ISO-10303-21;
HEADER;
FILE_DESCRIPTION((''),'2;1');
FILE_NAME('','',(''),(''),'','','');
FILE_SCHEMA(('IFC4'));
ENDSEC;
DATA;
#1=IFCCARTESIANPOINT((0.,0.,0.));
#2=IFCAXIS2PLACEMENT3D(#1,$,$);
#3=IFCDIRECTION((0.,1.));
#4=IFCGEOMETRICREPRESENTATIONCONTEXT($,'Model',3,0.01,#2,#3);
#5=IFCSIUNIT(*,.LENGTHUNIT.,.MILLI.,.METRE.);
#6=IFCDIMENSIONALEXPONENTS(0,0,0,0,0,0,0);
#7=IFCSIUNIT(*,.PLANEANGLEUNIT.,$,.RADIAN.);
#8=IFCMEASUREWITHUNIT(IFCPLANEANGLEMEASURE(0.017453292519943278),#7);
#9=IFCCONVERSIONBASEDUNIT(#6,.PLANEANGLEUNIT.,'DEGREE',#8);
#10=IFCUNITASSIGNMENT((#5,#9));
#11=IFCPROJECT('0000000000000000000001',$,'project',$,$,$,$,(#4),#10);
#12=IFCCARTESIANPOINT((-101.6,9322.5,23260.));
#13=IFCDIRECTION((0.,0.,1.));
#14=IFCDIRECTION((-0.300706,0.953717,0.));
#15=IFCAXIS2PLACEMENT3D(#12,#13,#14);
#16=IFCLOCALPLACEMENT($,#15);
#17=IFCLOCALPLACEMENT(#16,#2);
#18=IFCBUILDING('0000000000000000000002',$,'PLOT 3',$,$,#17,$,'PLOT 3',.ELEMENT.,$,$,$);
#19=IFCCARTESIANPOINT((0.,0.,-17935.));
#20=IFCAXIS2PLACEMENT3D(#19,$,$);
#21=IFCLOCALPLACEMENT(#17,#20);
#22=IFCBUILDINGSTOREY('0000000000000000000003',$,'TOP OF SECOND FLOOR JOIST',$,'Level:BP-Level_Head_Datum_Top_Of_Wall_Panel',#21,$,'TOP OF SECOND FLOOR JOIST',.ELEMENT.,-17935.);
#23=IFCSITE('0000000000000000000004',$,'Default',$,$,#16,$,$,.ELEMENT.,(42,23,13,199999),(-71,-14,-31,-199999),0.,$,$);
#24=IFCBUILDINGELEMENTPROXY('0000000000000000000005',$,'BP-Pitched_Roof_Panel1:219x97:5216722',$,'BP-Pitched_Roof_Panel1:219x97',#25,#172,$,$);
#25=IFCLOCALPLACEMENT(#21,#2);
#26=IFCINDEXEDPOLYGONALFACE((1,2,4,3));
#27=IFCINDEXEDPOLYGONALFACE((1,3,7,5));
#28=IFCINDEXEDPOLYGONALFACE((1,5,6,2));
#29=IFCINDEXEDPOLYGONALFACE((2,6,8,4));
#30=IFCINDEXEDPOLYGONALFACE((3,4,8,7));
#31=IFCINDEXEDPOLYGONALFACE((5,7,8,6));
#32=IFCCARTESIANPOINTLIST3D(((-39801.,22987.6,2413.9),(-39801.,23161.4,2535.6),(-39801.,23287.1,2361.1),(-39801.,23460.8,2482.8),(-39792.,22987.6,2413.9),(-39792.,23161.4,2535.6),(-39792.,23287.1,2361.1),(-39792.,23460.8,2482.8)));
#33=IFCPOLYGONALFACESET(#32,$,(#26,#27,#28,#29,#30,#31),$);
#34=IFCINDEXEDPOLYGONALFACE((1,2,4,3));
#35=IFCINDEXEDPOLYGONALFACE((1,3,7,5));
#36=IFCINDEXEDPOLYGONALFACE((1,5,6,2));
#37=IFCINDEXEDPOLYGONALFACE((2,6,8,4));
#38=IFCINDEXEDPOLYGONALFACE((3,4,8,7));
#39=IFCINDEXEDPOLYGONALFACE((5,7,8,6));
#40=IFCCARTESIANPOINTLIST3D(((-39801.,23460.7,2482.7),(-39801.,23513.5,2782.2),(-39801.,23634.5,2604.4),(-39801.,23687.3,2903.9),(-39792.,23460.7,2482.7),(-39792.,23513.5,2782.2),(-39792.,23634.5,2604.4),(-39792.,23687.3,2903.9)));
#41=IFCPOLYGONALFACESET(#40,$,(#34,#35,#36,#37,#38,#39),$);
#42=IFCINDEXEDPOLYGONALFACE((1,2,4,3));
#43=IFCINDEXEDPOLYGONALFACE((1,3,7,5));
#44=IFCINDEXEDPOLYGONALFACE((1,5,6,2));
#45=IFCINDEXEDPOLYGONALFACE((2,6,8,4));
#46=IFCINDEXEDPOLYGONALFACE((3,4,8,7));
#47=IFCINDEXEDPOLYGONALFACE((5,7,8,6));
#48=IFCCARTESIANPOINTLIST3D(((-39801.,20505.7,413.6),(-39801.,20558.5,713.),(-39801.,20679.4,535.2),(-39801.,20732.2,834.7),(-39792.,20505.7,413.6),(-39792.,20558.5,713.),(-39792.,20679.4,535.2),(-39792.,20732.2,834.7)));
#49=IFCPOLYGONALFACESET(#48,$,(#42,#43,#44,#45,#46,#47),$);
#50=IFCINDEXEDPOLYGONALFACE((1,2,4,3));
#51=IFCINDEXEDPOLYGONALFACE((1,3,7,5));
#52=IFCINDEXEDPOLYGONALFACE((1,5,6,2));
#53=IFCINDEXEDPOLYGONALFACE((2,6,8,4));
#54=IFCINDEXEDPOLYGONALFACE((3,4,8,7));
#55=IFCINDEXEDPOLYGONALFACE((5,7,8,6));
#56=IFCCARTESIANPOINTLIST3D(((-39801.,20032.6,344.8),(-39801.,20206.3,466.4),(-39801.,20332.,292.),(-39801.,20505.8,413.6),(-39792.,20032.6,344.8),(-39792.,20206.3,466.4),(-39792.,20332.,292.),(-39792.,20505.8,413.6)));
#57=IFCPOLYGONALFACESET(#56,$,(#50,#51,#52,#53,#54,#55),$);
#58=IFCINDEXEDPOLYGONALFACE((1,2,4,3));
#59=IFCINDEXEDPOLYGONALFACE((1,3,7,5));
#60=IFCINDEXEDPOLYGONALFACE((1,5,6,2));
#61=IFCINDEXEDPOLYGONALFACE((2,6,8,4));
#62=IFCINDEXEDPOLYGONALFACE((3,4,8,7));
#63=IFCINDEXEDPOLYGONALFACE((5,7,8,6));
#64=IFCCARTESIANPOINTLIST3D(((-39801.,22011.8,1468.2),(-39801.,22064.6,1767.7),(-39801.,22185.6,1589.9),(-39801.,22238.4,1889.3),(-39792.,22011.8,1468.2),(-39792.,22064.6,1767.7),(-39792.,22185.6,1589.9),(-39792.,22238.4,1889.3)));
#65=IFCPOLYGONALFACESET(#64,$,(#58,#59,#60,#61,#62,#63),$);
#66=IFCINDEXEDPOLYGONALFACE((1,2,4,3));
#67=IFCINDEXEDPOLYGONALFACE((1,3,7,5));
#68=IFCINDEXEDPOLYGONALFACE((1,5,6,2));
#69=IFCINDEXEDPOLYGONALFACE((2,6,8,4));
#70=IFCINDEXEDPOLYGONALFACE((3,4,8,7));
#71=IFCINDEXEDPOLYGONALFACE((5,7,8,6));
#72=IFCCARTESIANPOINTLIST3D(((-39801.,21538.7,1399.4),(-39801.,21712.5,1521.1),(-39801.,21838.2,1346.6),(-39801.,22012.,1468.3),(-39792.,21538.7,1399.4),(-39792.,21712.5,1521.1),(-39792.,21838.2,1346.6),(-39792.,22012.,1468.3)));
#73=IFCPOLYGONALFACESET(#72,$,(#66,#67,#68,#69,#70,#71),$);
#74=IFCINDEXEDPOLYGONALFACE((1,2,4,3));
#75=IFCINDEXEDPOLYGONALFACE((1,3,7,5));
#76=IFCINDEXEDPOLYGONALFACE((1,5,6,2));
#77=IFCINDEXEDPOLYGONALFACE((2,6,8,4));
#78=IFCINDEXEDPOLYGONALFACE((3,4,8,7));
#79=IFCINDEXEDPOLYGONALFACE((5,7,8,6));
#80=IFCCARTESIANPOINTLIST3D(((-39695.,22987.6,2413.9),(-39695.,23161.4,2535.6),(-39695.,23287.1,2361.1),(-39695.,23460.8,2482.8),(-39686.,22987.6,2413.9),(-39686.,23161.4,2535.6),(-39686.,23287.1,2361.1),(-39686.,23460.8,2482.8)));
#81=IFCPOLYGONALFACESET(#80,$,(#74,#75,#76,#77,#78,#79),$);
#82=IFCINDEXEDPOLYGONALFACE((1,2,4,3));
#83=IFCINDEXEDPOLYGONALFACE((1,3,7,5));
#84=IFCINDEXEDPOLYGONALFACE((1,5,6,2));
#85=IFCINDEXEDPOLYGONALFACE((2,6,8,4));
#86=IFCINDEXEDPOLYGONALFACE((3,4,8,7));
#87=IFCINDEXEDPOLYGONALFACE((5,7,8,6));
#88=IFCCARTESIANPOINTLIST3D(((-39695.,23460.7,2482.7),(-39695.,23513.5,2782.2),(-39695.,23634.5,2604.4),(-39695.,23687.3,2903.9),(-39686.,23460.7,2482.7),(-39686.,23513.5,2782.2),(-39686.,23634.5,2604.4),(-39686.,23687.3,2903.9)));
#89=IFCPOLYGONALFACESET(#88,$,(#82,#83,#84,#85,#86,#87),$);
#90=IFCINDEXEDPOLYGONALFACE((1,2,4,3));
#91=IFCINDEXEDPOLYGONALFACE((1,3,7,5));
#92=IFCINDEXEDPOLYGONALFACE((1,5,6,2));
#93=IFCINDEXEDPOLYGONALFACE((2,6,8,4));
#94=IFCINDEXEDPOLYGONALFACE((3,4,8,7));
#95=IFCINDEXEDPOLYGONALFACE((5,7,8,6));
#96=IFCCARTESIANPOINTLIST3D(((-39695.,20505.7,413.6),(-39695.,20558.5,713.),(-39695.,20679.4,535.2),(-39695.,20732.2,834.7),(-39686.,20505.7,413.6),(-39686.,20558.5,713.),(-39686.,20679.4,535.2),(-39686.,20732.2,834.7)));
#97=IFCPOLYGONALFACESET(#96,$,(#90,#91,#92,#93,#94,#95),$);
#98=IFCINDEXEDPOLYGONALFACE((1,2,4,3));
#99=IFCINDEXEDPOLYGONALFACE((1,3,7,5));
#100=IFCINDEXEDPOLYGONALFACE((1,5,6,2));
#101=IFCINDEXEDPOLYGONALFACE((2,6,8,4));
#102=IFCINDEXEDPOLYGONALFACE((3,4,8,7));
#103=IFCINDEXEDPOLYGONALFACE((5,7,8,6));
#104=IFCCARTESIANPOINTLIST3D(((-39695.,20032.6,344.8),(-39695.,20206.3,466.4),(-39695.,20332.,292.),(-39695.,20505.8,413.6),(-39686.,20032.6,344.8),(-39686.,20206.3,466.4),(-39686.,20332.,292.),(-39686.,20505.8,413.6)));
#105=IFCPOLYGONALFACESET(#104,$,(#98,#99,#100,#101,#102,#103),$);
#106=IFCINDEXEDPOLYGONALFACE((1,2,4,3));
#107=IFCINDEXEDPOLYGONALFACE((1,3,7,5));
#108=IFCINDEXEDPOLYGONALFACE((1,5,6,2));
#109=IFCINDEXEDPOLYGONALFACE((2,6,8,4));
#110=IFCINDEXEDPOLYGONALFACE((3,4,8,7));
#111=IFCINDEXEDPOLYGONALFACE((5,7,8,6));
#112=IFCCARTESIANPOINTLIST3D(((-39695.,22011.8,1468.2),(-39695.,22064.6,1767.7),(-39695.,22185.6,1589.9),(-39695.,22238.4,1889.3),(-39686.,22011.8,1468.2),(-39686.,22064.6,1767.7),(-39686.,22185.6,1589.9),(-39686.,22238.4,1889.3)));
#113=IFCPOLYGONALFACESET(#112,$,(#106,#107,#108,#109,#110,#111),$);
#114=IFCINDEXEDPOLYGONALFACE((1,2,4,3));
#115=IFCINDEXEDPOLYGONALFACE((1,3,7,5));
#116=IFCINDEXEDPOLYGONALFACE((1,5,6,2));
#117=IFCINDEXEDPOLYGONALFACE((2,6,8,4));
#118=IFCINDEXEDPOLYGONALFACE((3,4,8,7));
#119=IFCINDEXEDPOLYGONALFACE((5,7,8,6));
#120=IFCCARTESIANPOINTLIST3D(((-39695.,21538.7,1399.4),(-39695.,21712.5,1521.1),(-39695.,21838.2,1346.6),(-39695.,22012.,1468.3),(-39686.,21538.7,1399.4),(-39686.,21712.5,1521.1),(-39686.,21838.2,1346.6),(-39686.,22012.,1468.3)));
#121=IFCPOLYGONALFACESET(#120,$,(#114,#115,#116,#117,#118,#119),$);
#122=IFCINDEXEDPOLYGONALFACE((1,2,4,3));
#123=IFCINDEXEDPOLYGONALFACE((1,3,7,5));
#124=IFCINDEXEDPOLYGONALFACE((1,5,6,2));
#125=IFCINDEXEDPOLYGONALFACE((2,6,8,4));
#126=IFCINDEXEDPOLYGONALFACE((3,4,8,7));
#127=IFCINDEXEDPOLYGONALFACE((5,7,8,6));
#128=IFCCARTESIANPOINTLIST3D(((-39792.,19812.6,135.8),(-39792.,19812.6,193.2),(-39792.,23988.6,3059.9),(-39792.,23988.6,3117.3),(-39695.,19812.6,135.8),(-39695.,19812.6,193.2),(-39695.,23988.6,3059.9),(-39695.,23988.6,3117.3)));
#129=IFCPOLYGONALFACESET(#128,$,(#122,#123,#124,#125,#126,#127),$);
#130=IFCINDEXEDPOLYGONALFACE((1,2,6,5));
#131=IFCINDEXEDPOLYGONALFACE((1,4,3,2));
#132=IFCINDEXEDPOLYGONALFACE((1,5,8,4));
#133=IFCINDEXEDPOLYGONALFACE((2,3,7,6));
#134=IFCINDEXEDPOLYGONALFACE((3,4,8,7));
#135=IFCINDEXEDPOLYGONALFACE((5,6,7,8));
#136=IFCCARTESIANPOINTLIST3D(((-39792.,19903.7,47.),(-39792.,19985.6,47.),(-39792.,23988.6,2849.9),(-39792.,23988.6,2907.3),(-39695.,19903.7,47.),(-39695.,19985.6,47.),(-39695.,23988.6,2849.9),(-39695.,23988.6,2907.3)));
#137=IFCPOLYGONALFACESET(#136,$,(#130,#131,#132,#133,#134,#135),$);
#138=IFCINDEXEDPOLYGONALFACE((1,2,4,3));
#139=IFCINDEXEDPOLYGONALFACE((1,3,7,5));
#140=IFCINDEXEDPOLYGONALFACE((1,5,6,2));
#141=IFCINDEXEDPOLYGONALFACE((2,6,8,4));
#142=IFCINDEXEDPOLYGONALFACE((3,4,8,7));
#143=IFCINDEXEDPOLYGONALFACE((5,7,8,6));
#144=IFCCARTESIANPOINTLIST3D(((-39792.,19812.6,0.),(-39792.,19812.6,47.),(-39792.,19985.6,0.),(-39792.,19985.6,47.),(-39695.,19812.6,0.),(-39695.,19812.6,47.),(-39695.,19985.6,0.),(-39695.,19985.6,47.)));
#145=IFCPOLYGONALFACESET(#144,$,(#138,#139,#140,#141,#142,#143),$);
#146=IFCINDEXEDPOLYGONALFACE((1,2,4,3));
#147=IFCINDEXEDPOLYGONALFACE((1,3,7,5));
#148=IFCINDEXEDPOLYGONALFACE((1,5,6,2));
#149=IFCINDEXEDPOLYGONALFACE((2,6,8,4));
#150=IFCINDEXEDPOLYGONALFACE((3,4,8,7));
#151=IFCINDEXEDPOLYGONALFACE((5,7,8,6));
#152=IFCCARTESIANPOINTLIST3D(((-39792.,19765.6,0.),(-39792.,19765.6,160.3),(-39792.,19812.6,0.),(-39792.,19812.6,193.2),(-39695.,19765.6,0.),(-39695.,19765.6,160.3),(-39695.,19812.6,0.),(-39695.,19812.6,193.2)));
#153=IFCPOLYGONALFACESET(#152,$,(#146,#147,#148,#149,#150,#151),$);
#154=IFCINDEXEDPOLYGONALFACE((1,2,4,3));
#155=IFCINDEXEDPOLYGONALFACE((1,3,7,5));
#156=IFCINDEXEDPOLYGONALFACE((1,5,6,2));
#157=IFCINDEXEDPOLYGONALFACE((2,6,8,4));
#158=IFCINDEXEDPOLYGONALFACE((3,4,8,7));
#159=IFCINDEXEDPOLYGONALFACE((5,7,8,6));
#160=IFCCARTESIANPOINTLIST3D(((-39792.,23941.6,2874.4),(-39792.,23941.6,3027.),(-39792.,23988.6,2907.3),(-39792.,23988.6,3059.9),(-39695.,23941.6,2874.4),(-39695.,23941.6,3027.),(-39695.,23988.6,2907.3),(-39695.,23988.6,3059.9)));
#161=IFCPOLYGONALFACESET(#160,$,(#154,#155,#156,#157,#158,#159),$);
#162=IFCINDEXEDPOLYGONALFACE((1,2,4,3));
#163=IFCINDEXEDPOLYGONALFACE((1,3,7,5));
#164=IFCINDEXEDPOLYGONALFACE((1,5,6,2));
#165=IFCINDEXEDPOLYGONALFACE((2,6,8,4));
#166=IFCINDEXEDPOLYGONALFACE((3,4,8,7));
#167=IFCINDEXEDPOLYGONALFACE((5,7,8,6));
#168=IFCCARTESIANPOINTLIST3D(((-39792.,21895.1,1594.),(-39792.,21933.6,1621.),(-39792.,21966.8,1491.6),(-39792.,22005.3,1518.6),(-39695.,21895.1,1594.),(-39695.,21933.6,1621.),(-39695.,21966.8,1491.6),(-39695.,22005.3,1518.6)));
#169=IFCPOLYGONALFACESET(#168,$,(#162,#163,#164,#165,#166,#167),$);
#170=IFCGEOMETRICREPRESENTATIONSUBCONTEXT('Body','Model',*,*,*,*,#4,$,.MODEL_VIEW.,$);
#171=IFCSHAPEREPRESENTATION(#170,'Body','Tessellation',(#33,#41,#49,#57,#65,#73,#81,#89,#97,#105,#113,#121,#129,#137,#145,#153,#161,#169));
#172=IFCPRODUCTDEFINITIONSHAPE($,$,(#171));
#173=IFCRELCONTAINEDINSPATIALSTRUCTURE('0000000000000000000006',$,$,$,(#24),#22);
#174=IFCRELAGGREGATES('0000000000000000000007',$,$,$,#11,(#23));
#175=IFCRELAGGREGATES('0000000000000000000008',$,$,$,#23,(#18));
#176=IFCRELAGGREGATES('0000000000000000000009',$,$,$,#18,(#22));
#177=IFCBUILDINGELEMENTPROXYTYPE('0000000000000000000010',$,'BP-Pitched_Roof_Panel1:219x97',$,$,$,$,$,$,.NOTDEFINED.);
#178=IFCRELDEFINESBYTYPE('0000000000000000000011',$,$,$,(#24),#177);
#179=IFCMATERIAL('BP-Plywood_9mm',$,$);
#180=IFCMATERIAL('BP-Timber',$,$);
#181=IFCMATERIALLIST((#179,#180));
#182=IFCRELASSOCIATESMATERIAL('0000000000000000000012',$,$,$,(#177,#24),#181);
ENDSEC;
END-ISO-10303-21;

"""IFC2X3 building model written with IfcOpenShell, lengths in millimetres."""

from ifc_helpers import new_model, entity, si_unit, converted_unit, direction, frame, frame_2d, origin, origin_2d_with_axis, place, context, subcontext, project, spatial, polyline, rectangle, outline, extrude, source, transform, mapped, material, material_list, type_object, type_shapes, element, save


model = new_model("IFC2X3")

# Units and contexts
model_context = context("Model", 3, precision=0.01, world=origin(), true_north=direction((0.0, 1.0)))
body_context = subcontext(model_context, "Body", "Model", "MODEL_VIEW")
ifc_project = project(units=[si_unit("LENGTHUNIT", "METRE", prefix="MILLI"), converted_unit("PLANEANGLEUNIT", "DEGREE", entity("IfcPlaneAngleMeasure", 0.017453292519943278), si_unit("PLANEANGLEUNIT", "RADIAN"), dimensions=[0, 0, 0, 0, 0, 0, 0])], contexts=[model_context])

# Site, building, storey
site_placement = place(None, frame((-101.6, 9322.5, 23260.0), z_axis=(0.0, 0.0, 1.0), x_axis=(-0.300706, 0.953717, 0.0)))
site = spatial("IfcSite", under=ifc_project, at=site_placement, Name="Default", CompositionType="ELEMENT", RefLatitude=(42, 23, 13, 199999), RefLongitude=(-71, -14, -31, -199999), RefElevation=0.0)
building_placement = place(site_placement, origin())
building = spatial("IfcBuilding", under=site, at=building_placement, Name="PLOT 3", LongName="PLOT 3", CompositionType="ELEMENT")
storey_placement = place(building_placement, frame((0.0, 0.0, -17935.0)))
storey = spatial("IfcBuildingStorey", under=building, at=storey_placement, Name="TOP OF SECOND FLOOR JOIST", ObjectType="Level:BP-Level_Head_Datum_Top_Of_Wall_Panel", LongName="TOP OF SECOND FLOOR JOIST", CompositionType="ELEMENT", Elevation=-17935.0)

# Building element proxy
ifc_material_1 = material(Name="BP-Timber")
ifc_material_2 = material(Name="BP-Plywood_9mm")
ifc_material_list = material_list([ifc_material_2, ifc_material_1])
building_element_proxy_type_1 = type_object("IfcBuildingElementProxyType", Name="BP-Pitched_Roof_Panel1:219x97", PredefinedType="NOTDEFINED", material=ifc_material_list)
shared_shape_1 = source(origin(), body_context, "Body", "SweptSolid", [
    extrude(outline(polyline([(-77.0, -75.0), (227.0, -75.0), (77.0, 75.0), (-227.0, 75.0), (-77.0, -75.0)])), frame((36.3, 3947.0, 2448.4), z_axis=(0.0, 1.0, 0.0), x_axis=(-0.984808, 0.0, 0.173648)), (0.0, 0.0, 1.0), 9.0),
    extrude(outline(polyline([(1.4, -107.5), (213.6, -107.5), (-1.4, 107.5), (-213.6, 107.5), (1.4, -107.5)])), frame((386.1, 3947.0, 2693.3), z_axis=(0.0, 1.0, 0.0), x_axis=(-0.819152, 0.0, -0.573576)), (0.0, 0.0, 1.0), 9.0),
    extrude(outline(polyline([(1.4, -107.5), (213.6, -107.5), (-1.4, 107.5), (-213.6, 107.5), (1.4, -107.5)])), frame((-2569.0, 3947.0, 624.1), z_axis=(0.0, 1.0, 0.0), x_axis=(-0.819152, 0.0, -0.573576)), (0.0, 0.0, 1.0), 9.0),
    extrude(outline(polyline([(-77.0, -75.0), (227.0, -75.0), (77.0, 75.0), (-227.0, 75.0), (-77.0, -75.0)])), frame((-2918.8, 3947.0, 379.2), z_axis=(0.0, 1.0, 0.0), x_axis=(-0.984808, 0.0, 0.173648)), (0.0, 0.0, 1.0), 9.0),
    extrude(outline(polyline([(1.4, -107.5), (213.6, -107.5), (-1.4, 107.5), (-213.6, 107.5), (1.4, -107.5)])), frame((-1062.8, 3947.0, 1678.8), z_axis=(0.0, 1.0, 0.0), x_axis=(-0.819152, 0.0, -0.573576)), (0.0, 0.0, 1.0), 9.0),
    extrude(outline(polyline([(-77.0, -75.0), (227.0, -75.0), (77.0, 75.0), (-227.0, 75.0), (-77.0, -75.0)])), frame((-1412.6, 3947.0, 1433.9), z_axis=(0.0, 1.0, 0.0), x_axis=(-0.984808, 0.0, 0.173648)), (0.0, 0.0, 1.0), 9.0),
    extrude(outline(polyline([(-77.0, -75.0), (227.0, -75.0), (77.0, 75.0), (-227.0, 75.0), (-77.0, -75.0)])), frame((36.3, 3841.0, 2448.4), z_axis=(0.0, 1.0, 0.0), x_axis=(-0.984808, 0.0, 0.173648)), (0.0, 0.0, 1.0), 9.0),
    extrude(outline(polyline([(1.4, -107.5), (213.6, -107.5), (-1.4, 107.5), (-213.6, 107.5), (1.4, -107.5)])), frame((386.1, 3841.0, 2693.3), z_axis=(0.0, 1.0, 0.0), x_axis=(-0.819152, 0.0, -0.573576)), (0.0, 0.0, 1.0), 9.0),
    extrude(outline(polyline([(1.4, -107.5), (213.6, -107.5), (-1.4, 107.5), (-213.6, 107.5), (1.4, -107.5)])), frame((-2569.0, 3841.0, 624.1), z_axis=(0.0, 1.0, 0.0), x_axis=(-0.819152, 0.0, -0.573576)), (0.0, 0.0, 1.0), 9.0),
    extrude(outline(polyline([(-77.0, -75.0), (227.0, -75.0), (77.0, 75.0), (-227.0, 75.0), (-77.0, -75.0)])), frame((-2918.8, 3841.0, 379.2), z_axis=(0.0, 1.0, 0.0), x_axis=(-0.984808, 0.0, 0.173648)), (0.0, 0.0, 1.0), 9.0),
    extrude(outline(polyline([(1.4, -107.5), (213.6, -107.5), (-1.4, 107.5), (-213.6, 107.5), (1.4, -107.5)])), frame((-1062.8, 3841.0, 1678.8), z_axis=(0.0, 1.0, 0.0), x_axis=(-0.819152, 0.0, -0.573576)), (0.0, 0.0, 1.0), 9.0),
    extrude(outline(polyline([(-77.0, -75.0), (227.0, -75.0), (77.0, 75.0), (-227.0, 75.0), (-77.0, -75.0)])), frame((-1412.6, 3841.0, 1433.9), z_axis=(0.0, 1.0, 0.0), x_axis=(-0.984808, 0.0, 0.173648)), (0.0, 0.0, 1.0), 9.0),
    extrude(outline(polyline([(-1490.7, -2088.0), (-1433.3, -2088.0), (1490.7, 2088.0), (1433.3, 2088.0), (-1490.7, -2088.0)])), frame((-1287.3, 3850.0, 1626.6), z_axis=(0.0, 1.0, 0.0), x_axis=(0.0, 0.0, -1.0)), (0.0, 0.0, 1.0), 97.0),
    extrude(outline(polyline([(-1444.5, -2022.0), (-1387.1, -2022.0), (1415.8, 1981.0), (1415.8, 2063.0), (-1444.5, -2022.0)])), frame((-1221.3, 3850.0, 1462.8), z_axis=(0.0, 1.0, 0.0), x_axis=(0.0, 0.0, -1.0)), (0.0, 0.0, 1.0), 97.0),
    extrude(rectangle(XDim=97.0, YDim=173.0, at=origin_2d_with_axis()), frame((-3288.8, 3898.5, 0.0), z_axis=(0.0, 0.0, 1.0), x_axis=(0.0, 1.0, 0.0)), (0.0, 0.0, 1.0), 47.0),
    extrude(outline(polyline([(22.0, -72.4), (79.4, -72.4), (-31.4, 85.9), (-69.9, 58.9), (22.0, -72.4)])), frame((-3398.8, 3850.0, 88.4), z_axis=(0.0, 1.0, 0.0), x_axis=(0.819152, 0.0, 0.573576)), (0.0, 0.0, 1.0), 97.0),
    extrude(outline(polyline([(15.1, -62.5), (72.5, -62.5), (-15.1, 62.5), (-72.5, 62.5), (15.1, -62.5)])), frame((777.2, 3850.0, 2967.2), z_axis=(0.0, 1.0, 0.0), x_axis=(0.819152, 0.0, 0.573576)), (0.0, 0.0, 1.0), 97.0),
    extrude(rectangle(XDim=47.0, YDim=97.0, at=frame_2d((0.0, 0.0), x_axis=(0.0, 1.0))), frame((-1201.9, 3898.5, 1505.1), z_axis=(-0.573576, 0.0, 0.819152), x_axis=(0.0, 1.0, 0.0)), (0.0, 0.0, 1.0), 125.0),
])
type_shapes(building_element_proxy_type_1, [shared_shape_1])
for number, where, z_axis, x_axis, name in (
    (1, (-35845.0, 23187.9, 0.0), (0.0, 0.0, 1.0), (0.0, 1.0, 0.0), "BP-Pitched_Roof_Panel1:219x97:5216722"),
):
    element("IfcBuildingElementProxy", number, at=place(storey_placement, frame(where, z_axis=z_axis, x_axis=x_axis)), inside=storey, type_object=building_element_proxy_type_1, material=ifc_material_list, Name=name, ObjectType="BP-Pitched_Roof_Panel1:219x97", context=body_context, shape_type="MappedRepresentation", body=[
        mapped(shared_shape_1, transform((0.0, 0.0, 0.0), scale=1.0)),
    ])

save(model, "model.ifc")
